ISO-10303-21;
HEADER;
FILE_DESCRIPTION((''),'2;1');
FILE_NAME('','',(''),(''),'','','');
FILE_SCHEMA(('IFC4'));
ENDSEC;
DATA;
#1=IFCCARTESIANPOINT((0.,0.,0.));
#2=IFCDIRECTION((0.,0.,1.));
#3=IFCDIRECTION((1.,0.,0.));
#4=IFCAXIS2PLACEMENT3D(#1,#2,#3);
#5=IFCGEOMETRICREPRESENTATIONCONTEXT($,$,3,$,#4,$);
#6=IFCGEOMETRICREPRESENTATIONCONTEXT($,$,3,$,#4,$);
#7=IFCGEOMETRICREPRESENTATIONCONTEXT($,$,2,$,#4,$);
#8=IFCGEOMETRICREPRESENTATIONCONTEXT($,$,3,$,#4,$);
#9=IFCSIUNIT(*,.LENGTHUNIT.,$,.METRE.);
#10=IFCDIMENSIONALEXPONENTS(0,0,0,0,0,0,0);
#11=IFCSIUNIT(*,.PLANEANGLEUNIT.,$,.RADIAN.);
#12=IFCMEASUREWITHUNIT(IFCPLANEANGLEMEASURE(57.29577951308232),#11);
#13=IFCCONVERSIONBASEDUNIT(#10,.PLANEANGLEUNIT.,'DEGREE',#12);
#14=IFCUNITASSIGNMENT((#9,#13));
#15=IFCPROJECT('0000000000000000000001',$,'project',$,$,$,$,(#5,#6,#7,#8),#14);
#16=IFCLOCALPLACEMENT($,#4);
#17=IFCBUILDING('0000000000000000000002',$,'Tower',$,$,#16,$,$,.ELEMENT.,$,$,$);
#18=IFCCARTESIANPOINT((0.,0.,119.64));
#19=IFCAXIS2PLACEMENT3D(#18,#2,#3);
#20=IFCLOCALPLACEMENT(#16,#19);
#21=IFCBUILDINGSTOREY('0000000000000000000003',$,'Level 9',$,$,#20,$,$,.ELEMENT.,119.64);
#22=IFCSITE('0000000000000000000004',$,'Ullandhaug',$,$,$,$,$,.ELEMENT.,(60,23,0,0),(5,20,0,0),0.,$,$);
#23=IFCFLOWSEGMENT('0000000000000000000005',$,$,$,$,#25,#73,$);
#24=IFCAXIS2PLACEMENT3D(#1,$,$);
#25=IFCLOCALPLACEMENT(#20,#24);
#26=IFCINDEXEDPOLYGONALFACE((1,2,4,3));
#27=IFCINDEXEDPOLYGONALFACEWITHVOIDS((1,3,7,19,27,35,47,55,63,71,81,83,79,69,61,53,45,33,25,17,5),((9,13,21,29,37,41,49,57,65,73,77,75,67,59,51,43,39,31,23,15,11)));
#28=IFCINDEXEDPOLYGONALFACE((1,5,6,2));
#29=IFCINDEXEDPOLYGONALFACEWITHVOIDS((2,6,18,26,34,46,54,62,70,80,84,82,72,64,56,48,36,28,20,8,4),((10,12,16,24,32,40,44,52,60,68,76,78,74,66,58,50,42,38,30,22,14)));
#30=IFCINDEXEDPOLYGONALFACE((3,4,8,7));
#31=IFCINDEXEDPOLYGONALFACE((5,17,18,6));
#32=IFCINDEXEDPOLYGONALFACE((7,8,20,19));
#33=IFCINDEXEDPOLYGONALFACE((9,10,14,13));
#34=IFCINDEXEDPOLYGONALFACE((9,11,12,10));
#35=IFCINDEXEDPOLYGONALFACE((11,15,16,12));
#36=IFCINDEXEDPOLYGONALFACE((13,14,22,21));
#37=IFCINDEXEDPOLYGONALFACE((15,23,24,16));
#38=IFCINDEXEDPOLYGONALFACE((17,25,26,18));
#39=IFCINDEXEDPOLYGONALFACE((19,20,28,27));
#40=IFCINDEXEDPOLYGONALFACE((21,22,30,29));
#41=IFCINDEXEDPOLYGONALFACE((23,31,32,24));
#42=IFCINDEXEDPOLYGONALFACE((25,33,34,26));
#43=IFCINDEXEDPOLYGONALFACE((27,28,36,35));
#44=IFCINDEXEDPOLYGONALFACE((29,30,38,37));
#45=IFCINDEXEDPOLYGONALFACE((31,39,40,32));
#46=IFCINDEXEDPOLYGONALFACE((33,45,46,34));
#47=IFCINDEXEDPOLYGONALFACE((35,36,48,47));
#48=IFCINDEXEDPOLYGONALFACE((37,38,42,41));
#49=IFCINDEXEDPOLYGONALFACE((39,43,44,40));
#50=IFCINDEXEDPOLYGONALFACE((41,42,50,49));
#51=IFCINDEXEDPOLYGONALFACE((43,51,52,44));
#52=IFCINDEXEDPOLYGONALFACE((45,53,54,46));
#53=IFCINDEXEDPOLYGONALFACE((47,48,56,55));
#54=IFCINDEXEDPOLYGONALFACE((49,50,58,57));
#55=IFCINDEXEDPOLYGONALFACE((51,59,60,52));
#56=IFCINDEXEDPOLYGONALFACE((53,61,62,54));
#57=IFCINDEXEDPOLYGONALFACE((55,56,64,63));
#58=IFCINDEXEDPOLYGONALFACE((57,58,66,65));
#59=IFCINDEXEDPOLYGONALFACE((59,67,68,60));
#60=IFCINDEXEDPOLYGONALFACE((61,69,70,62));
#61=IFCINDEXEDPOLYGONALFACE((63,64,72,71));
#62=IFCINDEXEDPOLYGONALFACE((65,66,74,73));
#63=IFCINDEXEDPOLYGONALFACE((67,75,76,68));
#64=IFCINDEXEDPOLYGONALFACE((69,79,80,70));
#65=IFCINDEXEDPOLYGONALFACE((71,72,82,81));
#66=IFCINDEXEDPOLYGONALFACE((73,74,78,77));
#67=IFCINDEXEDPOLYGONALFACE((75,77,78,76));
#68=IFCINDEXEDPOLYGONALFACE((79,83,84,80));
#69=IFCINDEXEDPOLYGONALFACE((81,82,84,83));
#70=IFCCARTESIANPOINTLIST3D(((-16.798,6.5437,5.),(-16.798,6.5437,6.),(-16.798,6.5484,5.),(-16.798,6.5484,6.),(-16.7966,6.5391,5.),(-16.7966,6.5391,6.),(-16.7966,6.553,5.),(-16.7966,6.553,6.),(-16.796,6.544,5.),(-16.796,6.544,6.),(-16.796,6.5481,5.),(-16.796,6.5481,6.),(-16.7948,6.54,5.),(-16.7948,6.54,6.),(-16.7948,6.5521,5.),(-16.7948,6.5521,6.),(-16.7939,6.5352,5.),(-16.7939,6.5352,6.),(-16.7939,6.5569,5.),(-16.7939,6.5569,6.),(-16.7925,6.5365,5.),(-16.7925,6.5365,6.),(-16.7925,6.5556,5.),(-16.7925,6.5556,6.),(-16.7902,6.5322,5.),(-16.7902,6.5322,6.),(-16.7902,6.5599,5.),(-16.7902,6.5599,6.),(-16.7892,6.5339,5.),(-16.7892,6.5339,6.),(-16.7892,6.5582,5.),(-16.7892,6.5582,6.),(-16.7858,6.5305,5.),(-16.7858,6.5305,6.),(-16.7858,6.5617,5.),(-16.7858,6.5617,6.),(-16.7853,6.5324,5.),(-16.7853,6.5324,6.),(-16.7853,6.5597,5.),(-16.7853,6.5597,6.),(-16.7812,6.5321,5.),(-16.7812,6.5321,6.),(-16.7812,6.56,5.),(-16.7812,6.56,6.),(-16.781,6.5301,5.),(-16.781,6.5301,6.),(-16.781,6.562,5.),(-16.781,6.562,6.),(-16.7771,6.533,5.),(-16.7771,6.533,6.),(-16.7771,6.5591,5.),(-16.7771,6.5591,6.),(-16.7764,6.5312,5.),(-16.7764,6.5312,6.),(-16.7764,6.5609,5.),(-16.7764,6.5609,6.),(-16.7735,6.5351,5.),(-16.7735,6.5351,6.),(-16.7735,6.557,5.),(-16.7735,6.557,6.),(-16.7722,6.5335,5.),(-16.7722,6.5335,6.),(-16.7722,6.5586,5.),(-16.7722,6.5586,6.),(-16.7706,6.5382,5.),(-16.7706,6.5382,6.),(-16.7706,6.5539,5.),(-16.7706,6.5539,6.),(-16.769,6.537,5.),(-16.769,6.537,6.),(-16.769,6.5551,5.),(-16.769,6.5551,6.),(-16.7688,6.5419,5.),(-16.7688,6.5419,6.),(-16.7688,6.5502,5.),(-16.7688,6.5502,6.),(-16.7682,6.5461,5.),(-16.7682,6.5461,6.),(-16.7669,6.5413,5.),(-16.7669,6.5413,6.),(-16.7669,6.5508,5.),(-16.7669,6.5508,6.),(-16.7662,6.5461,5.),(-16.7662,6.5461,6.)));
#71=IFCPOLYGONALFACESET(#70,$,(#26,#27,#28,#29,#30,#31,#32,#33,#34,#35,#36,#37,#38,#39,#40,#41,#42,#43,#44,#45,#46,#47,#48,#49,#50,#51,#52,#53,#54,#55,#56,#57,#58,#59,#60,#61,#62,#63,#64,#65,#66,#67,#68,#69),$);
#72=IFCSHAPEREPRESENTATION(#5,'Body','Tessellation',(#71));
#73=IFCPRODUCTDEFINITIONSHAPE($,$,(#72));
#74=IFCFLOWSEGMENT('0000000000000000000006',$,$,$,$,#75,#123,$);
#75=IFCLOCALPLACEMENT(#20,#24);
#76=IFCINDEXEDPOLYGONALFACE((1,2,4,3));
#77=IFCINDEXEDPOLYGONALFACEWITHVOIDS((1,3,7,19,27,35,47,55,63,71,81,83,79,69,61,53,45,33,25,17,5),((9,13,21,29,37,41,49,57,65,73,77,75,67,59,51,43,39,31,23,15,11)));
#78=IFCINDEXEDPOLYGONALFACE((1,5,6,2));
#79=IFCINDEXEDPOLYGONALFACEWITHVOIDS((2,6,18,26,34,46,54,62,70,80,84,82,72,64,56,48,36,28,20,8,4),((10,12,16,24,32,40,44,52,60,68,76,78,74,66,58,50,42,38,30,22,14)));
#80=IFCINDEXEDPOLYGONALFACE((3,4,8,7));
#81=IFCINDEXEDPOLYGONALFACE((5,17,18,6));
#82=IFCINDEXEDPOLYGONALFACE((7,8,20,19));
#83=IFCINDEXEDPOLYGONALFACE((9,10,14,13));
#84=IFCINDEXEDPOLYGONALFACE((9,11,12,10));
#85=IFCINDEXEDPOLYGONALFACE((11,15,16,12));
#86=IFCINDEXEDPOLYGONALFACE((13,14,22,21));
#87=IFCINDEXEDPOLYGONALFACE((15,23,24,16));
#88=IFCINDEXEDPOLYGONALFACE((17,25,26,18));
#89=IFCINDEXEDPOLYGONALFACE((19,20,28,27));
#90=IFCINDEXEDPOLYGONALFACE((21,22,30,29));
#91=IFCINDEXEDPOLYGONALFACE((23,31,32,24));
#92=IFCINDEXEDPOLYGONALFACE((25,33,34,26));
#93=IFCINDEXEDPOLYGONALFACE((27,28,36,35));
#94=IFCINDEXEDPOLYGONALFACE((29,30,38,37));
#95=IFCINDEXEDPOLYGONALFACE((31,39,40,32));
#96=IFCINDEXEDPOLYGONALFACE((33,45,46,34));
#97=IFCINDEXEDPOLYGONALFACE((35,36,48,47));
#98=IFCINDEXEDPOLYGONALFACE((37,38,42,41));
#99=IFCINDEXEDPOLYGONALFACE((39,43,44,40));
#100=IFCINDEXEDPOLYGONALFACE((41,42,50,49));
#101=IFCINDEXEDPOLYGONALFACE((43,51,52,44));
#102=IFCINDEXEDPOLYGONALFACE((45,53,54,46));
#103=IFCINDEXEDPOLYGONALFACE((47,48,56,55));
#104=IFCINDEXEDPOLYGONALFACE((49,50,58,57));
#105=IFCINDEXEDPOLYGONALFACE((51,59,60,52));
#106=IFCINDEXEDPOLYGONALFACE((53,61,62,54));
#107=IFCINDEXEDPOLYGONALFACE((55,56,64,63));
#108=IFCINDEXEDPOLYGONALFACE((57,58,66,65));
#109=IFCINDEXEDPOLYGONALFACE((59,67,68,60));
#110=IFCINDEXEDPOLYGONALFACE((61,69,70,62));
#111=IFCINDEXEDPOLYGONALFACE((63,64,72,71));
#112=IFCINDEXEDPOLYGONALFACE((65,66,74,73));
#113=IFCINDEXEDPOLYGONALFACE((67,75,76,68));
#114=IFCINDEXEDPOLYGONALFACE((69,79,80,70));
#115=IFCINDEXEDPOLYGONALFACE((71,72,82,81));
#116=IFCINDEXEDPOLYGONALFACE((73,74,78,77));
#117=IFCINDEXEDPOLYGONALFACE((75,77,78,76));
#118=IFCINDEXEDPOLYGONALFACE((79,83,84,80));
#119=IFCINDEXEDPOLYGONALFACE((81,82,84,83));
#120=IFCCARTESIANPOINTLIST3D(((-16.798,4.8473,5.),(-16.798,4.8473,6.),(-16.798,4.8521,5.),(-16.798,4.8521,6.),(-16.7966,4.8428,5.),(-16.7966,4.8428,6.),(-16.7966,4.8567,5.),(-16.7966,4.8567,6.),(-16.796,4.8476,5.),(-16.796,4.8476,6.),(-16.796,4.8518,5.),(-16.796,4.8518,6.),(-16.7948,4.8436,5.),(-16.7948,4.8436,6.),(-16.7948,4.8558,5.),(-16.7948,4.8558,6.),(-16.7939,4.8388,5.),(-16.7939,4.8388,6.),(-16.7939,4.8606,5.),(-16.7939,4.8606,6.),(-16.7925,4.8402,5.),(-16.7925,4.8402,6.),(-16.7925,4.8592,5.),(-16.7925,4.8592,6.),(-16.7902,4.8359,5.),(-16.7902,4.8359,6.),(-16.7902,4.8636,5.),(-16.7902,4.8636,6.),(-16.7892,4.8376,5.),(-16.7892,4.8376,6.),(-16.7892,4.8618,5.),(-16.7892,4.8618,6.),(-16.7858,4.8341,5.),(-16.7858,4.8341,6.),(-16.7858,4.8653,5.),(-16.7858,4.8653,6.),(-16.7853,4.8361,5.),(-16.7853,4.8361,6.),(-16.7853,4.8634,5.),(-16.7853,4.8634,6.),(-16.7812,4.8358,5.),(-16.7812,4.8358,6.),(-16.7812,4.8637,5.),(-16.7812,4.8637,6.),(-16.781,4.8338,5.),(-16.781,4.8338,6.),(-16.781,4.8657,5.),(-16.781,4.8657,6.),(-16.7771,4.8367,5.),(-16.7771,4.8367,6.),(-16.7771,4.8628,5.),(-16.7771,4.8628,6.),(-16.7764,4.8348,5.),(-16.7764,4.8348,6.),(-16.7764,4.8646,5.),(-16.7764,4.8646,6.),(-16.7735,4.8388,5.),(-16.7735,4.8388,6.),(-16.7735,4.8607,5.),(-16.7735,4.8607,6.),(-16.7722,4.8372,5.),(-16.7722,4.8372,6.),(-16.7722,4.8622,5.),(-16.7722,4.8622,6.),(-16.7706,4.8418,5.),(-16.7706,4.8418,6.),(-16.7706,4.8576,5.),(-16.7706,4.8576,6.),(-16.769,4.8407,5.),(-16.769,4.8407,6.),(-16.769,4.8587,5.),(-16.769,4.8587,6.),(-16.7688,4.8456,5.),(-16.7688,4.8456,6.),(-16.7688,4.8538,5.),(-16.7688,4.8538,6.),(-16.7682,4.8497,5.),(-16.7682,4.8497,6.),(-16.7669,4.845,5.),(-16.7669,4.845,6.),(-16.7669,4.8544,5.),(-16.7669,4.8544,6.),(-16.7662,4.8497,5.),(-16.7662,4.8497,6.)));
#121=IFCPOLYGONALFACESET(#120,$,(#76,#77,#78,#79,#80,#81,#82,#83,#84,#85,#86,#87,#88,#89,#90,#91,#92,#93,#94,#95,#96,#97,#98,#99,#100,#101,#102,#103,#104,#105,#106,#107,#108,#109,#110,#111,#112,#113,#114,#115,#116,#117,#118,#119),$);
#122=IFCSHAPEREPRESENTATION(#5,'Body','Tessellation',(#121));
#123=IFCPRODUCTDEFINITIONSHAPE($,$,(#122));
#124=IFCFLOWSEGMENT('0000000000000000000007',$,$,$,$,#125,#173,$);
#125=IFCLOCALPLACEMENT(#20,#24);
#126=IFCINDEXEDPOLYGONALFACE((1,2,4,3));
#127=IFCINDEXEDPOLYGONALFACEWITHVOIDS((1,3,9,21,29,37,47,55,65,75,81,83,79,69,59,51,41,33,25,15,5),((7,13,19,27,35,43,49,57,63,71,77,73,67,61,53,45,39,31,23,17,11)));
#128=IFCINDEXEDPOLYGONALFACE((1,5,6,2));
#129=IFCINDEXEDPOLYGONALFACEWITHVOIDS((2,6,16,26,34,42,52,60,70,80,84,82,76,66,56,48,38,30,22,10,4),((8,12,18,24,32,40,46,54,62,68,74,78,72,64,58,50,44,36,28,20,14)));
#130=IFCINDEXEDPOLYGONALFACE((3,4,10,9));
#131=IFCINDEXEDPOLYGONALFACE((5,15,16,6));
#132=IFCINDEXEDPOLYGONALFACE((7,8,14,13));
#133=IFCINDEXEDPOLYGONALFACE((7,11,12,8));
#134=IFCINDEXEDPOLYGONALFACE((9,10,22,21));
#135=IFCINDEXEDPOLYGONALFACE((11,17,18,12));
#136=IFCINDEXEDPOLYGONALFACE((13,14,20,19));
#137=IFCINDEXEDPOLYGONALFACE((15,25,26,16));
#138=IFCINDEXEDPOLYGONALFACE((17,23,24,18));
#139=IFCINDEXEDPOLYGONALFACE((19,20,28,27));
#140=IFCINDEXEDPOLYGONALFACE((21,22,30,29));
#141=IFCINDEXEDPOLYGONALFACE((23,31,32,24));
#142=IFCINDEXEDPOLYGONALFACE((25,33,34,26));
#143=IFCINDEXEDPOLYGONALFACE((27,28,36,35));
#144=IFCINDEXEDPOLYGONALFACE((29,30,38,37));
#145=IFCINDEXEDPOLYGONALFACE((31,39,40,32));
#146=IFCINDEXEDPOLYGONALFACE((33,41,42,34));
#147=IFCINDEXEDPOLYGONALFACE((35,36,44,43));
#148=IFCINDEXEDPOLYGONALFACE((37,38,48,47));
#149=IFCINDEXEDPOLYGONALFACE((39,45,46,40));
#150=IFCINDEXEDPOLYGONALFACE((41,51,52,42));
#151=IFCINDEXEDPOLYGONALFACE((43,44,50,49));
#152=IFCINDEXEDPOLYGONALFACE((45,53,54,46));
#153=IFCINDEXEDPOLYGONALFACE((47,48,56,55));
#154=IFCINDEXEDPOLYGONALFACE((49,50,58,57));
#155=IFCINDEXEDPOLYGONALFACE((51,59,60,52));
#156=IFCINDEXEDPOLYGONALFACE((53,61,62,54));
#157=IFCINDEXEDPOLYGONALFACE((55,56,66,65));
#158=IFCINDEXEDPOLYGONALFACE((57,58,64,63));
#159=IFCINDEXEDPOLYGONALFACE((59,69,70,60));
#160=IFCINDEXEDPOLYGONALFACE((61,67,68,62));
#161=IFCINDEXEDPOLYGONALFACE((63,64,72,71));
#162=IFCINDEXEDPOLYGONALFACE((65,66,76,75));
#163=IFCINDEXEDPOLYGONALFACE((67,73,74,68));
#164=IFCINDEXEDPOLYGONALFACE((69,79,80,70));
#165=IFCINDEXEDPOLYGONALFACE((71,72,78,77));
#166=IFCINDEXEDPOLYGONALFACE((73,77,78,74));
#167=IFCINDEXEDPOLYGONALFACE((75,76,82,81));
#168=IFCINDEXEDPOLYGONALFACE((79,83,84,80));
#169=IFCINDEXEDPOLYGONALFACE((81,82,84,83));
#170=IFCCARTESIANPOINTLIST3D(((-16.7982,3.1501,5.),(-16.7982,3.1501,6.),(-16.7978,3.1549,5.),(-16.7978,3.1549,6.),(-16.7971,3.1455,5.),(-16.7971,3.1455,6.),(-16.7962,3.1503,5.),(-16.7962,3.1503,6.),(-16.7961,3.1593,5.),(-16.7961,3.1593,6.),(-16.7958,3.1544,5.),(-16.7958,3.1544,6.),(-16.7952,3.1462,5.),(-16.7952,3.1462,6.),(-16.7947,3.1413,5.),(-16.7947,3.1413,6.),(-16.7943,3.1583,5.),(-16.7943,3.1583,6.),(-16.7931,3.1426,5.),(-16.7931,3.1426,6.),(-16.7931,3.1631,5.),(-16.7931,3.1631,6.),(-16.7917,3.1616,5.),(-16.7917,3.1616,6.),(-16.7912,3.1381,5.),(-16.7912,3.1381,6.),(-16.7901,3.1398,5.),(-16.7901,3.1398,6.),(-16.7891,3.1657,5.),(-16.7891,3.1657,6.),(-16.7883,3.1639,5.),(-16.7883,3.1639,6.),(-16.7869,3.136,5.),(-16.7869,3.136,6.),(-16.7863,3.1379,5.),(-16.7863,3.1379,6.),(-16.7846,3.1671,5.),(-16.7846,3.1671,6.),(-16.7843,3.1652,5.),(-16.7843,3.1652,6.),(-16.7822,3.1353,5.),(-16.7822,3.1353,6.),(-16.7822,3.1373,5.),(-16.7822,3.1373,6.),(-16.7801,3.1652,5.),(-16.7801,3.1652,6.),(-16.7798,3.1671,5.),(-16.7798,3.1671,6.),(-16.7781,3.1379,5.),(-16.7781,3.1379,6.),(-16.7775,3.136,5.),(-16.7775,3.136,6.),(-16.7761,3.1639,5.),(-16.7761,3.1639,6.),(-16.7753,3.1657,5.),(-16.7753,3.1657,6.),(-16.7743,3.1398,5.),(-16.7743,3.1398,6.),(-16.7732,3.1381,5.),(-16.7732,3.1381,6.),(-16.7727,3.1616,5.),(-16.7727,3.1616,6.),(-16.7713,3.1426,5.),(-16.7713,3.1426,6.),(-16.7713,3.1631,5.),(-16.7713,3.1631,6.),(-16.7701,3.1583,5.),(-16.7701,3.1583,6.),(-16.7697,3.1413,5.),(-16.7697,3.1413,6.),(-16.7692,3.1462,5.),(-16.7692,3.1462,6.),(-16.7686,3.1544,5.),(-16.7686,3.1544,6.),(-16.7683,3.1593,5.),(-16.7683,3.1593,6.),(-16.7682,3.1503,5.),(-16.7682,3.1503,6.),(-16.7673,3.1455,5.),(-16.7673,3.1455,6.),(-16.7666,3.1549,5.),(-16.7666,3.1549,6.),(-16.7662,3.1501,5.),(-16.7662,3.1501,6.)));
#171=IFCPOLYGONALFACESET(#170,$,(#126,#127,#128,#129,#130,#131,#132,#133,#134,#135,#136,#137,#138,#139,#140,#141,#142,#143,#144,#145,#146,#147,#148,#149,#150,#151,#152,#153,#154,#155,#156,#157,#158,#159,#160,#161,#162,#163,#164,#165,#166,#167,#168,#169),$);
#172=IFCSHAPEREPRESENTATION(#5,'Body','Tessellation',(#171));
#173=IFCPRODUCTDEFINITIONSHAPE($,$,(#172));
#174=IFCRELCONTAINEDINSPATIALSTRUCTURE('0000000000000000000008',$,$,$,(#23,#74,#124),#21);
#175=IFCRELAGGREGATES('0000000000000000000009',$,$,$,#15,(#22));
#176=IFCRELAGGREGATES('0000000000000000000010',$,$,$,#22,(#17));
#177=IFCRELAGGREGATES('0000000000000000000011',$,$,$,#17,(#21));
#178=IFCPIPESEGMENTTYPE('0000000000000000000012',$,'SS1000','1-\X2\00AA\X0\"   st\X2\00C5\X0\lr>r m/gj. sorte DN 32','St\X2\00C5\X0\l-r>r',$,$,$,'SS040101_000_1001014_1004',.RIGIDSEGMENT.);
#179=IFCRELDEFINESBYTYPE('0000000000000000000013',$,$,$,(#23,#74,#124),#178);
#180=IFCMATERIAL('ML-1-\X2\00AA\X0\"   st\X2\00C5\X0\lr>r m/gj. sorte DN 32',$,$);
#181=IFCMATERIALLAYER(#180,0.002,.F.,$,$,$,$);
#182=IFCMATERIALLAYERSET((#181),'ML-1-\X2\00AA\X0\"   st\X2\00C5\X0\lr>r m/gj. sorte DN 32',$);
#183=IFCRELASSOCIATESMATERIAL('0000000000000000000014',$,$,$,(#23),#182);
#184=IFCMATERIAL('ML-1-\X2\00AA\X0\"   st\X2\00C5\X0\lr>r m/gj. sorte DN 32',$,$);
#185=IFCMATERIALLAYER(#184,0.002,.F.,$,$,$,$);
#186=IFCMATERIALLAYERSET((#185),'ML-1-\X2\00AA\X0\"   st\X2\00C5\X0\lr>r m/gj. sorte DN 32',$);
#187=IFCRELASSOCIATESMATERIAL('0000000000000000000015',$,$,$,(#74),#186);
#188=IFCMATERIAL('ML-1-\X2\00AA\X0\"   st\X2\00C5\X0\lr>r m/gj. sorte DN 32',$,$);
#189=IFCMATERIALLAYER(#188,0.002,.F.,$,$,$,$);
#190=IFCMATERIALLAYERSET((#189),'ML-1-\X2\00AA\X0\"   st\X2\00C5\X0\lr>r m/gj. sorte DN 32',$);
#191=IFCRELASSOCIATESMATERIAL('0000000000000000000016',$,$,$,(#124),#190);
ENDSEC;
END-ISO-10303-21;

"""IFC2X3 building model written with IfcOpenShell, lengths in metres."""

from ifc_helpers import new_model, entity, si_unit, converted_unit, frame, origin_with_axes, origin_2d_with_axis, place, context, project, spatial, hollow_circle, extrude, material, layer, layer_set, layer_usage, type_object, element, save


model = new_model("IFC2X3")

# Units and contexts
context_of_model_1 = context(None, 3, world=origin_with_axes())
context_of_model_2 = context(None, 3, world=origin_with_axes())
context_of_model_3 = context(None, 2, world=origin_with_axes())
context_of_model_4 = context(None, 3, world=origin_with_axes())
ifc_project = project(units=[si_unit("LENGTHUNIT", "METRE"), converted_unit("PLANEANGLEUNIT", "DEGREE", entity("IfcPlaneAngleMeasure", 57.29577951308232), si_unit("PLANEANGLEUNIT", "RADIAN"), dimensions=[0, 0, 0, 0, 0, 0, 0])], contexts=[context_of_model_1, context_of_model_2, context_of_model_3, context_of_model_4])

# Site, building, storey
site = spatial("IfcSite", under=ifc_project, Name="Ullandhaug", CompositionType="ELEMENT", RefLatitude=(60, 23, 0, 0), RefLongitude=(5, 20, 0, 0), RefElevation=0.0)
building_placement = place(None, origin_with_axes())
building = spatial("IfcBuilding", under=site, at=building_placement, Name="Tower", CompositionType="ELEMENT")
storey_placement = place(building_placement, frame((0.0, 0.0, 119.64), z_axis=(0.0, 0.0, 1.0), x_axis=(1.0, 0.0, 0.0)))
storey = spatial("IfcBuildingStorey", under=building, at=storey_placement, Name="Level 9", CompositionType="ELEMENT", Elevation=119.64)

# Flow segments
pipe_segment_type_1 = type_object("IfcPipeSegmentType", Name="SS1000", Description="1-ª\"   stÅlr>r m/gj. sorte DN 32", ApplicableOccurrence="StÅl-r>r", ElementType="SS040101_000_1001014_1004", PredefinedType="RIGIDSEGMENT")
ifc_material_1 = material(Name="ML-1-ª\"   stÅlr>r m/gj. sorte DN 32")
ifc_layer_1 = layer(ifc_material_1, 0.002, ventilated=False)
ifc_layer_set_1 = layer_set([ifc_layer_1], Name="ML-1-ª\"   stÅlr>r m/gj. sorte DN 32")
ifc_layer_usage_1 = layer_usage(ifc_layer_set_1, "AXIS2", "POSITIVE", 0.0)
flow_segment_1_placement = place(storey_placement, frame((-16.7822, 6.5461, 5.0), z_axis=(0.0, 0.0, 1.0), x_axis=(1.0, 0.0, 0.0)))
element("IfcFlowSegment", 1, at=flow_segment_1_placement, inside=storey, type_object=pipe_segment_type_1, material=ifc_layer_usage_1, context=context_of_model_1, shape_type="SweptSolid", body=[
    extrude(hollow_circle(Radius=0.016, WallThickness=0.002, at=origin_2d_with_axis()), origin_with_axes(), (0.0, 0.0, 1.0), 1.0),
])
ifc_material_2 = material(Name="ML-1-ª\"   stÅlr>r m/gj. sorte DN 32")
ifc_layer_2 = layer(ifc_material_2, 0.002, ventilated=False)
ifc_layer_set_2 = layer_set([ifc_layer_2], Name="ML-1-ª\"   stÅlr>r m/gj. sorte DN 32")
ifc_layer_usage_2 = layer_usage(ifc_layer_set_2, "AXIS2", "POSITIVE", 0.0)
flow_segment_2_placement = place(storey_placement, frame((-16.7822, 4.8497, 5.0), z_axis=(0.0, 0.0, 1.0), x_axis=(1.0, 0.0, 0.0)))
element("IfcFlowSegment", 2, at=flow_segment_2_placement, inside=storey, type_object=pipe_segment_type_1, material=ifc_layer_usage_2, context=context_of_model_1, shape_type="SweptSolid", body=[
    extrude(hollow_circle(Radius=0.016, WallThickness=0.002, at=origin_2d_with_axis()), origin_with_axes(), (0.0, 0.0, 1.0), 1.0),
])
ifc_material_3 = material(Name="ML-1-ª\"   stÅlr>r m/gj. sorte DN 32")
ifc_layer_3 = layer(ifc_material_3, 0.002, ventilated=False)
ifc_layer_set_3 = layer_set([ifc_layer_3], Name="ML-1-ª\"   stÅlr>r m/gj. sorte DN 32")
ifc_layer_usage_3 = layer_usage(ifc_layer_set_3, "AXIS2", "POSITIVE", 0.0)
flow_segment_3_placement = place(storey_placement, frame((-16.7822, 3.1513, 5.0), z_axis=(0.0, 0.0, 1.0), x_axis=(0.0, -1.0, 0.0)))
element("IfcFlowSegment", 3, at=flow_segment_3_placement, inside=storey, type_object=pipe_segment_type_1, material=ifc_layer_usage_3, context=context_of_model_1, shape_type="SweptSolid", body=[
    extrude(hollow_circle(Radius=0.016, WallThickness=0.002, at=origin_2d_with_axis()), origin_with_axes(), (0.0, 0.0, 1.0), 1.0),
])

save(model, "model.ifc")
